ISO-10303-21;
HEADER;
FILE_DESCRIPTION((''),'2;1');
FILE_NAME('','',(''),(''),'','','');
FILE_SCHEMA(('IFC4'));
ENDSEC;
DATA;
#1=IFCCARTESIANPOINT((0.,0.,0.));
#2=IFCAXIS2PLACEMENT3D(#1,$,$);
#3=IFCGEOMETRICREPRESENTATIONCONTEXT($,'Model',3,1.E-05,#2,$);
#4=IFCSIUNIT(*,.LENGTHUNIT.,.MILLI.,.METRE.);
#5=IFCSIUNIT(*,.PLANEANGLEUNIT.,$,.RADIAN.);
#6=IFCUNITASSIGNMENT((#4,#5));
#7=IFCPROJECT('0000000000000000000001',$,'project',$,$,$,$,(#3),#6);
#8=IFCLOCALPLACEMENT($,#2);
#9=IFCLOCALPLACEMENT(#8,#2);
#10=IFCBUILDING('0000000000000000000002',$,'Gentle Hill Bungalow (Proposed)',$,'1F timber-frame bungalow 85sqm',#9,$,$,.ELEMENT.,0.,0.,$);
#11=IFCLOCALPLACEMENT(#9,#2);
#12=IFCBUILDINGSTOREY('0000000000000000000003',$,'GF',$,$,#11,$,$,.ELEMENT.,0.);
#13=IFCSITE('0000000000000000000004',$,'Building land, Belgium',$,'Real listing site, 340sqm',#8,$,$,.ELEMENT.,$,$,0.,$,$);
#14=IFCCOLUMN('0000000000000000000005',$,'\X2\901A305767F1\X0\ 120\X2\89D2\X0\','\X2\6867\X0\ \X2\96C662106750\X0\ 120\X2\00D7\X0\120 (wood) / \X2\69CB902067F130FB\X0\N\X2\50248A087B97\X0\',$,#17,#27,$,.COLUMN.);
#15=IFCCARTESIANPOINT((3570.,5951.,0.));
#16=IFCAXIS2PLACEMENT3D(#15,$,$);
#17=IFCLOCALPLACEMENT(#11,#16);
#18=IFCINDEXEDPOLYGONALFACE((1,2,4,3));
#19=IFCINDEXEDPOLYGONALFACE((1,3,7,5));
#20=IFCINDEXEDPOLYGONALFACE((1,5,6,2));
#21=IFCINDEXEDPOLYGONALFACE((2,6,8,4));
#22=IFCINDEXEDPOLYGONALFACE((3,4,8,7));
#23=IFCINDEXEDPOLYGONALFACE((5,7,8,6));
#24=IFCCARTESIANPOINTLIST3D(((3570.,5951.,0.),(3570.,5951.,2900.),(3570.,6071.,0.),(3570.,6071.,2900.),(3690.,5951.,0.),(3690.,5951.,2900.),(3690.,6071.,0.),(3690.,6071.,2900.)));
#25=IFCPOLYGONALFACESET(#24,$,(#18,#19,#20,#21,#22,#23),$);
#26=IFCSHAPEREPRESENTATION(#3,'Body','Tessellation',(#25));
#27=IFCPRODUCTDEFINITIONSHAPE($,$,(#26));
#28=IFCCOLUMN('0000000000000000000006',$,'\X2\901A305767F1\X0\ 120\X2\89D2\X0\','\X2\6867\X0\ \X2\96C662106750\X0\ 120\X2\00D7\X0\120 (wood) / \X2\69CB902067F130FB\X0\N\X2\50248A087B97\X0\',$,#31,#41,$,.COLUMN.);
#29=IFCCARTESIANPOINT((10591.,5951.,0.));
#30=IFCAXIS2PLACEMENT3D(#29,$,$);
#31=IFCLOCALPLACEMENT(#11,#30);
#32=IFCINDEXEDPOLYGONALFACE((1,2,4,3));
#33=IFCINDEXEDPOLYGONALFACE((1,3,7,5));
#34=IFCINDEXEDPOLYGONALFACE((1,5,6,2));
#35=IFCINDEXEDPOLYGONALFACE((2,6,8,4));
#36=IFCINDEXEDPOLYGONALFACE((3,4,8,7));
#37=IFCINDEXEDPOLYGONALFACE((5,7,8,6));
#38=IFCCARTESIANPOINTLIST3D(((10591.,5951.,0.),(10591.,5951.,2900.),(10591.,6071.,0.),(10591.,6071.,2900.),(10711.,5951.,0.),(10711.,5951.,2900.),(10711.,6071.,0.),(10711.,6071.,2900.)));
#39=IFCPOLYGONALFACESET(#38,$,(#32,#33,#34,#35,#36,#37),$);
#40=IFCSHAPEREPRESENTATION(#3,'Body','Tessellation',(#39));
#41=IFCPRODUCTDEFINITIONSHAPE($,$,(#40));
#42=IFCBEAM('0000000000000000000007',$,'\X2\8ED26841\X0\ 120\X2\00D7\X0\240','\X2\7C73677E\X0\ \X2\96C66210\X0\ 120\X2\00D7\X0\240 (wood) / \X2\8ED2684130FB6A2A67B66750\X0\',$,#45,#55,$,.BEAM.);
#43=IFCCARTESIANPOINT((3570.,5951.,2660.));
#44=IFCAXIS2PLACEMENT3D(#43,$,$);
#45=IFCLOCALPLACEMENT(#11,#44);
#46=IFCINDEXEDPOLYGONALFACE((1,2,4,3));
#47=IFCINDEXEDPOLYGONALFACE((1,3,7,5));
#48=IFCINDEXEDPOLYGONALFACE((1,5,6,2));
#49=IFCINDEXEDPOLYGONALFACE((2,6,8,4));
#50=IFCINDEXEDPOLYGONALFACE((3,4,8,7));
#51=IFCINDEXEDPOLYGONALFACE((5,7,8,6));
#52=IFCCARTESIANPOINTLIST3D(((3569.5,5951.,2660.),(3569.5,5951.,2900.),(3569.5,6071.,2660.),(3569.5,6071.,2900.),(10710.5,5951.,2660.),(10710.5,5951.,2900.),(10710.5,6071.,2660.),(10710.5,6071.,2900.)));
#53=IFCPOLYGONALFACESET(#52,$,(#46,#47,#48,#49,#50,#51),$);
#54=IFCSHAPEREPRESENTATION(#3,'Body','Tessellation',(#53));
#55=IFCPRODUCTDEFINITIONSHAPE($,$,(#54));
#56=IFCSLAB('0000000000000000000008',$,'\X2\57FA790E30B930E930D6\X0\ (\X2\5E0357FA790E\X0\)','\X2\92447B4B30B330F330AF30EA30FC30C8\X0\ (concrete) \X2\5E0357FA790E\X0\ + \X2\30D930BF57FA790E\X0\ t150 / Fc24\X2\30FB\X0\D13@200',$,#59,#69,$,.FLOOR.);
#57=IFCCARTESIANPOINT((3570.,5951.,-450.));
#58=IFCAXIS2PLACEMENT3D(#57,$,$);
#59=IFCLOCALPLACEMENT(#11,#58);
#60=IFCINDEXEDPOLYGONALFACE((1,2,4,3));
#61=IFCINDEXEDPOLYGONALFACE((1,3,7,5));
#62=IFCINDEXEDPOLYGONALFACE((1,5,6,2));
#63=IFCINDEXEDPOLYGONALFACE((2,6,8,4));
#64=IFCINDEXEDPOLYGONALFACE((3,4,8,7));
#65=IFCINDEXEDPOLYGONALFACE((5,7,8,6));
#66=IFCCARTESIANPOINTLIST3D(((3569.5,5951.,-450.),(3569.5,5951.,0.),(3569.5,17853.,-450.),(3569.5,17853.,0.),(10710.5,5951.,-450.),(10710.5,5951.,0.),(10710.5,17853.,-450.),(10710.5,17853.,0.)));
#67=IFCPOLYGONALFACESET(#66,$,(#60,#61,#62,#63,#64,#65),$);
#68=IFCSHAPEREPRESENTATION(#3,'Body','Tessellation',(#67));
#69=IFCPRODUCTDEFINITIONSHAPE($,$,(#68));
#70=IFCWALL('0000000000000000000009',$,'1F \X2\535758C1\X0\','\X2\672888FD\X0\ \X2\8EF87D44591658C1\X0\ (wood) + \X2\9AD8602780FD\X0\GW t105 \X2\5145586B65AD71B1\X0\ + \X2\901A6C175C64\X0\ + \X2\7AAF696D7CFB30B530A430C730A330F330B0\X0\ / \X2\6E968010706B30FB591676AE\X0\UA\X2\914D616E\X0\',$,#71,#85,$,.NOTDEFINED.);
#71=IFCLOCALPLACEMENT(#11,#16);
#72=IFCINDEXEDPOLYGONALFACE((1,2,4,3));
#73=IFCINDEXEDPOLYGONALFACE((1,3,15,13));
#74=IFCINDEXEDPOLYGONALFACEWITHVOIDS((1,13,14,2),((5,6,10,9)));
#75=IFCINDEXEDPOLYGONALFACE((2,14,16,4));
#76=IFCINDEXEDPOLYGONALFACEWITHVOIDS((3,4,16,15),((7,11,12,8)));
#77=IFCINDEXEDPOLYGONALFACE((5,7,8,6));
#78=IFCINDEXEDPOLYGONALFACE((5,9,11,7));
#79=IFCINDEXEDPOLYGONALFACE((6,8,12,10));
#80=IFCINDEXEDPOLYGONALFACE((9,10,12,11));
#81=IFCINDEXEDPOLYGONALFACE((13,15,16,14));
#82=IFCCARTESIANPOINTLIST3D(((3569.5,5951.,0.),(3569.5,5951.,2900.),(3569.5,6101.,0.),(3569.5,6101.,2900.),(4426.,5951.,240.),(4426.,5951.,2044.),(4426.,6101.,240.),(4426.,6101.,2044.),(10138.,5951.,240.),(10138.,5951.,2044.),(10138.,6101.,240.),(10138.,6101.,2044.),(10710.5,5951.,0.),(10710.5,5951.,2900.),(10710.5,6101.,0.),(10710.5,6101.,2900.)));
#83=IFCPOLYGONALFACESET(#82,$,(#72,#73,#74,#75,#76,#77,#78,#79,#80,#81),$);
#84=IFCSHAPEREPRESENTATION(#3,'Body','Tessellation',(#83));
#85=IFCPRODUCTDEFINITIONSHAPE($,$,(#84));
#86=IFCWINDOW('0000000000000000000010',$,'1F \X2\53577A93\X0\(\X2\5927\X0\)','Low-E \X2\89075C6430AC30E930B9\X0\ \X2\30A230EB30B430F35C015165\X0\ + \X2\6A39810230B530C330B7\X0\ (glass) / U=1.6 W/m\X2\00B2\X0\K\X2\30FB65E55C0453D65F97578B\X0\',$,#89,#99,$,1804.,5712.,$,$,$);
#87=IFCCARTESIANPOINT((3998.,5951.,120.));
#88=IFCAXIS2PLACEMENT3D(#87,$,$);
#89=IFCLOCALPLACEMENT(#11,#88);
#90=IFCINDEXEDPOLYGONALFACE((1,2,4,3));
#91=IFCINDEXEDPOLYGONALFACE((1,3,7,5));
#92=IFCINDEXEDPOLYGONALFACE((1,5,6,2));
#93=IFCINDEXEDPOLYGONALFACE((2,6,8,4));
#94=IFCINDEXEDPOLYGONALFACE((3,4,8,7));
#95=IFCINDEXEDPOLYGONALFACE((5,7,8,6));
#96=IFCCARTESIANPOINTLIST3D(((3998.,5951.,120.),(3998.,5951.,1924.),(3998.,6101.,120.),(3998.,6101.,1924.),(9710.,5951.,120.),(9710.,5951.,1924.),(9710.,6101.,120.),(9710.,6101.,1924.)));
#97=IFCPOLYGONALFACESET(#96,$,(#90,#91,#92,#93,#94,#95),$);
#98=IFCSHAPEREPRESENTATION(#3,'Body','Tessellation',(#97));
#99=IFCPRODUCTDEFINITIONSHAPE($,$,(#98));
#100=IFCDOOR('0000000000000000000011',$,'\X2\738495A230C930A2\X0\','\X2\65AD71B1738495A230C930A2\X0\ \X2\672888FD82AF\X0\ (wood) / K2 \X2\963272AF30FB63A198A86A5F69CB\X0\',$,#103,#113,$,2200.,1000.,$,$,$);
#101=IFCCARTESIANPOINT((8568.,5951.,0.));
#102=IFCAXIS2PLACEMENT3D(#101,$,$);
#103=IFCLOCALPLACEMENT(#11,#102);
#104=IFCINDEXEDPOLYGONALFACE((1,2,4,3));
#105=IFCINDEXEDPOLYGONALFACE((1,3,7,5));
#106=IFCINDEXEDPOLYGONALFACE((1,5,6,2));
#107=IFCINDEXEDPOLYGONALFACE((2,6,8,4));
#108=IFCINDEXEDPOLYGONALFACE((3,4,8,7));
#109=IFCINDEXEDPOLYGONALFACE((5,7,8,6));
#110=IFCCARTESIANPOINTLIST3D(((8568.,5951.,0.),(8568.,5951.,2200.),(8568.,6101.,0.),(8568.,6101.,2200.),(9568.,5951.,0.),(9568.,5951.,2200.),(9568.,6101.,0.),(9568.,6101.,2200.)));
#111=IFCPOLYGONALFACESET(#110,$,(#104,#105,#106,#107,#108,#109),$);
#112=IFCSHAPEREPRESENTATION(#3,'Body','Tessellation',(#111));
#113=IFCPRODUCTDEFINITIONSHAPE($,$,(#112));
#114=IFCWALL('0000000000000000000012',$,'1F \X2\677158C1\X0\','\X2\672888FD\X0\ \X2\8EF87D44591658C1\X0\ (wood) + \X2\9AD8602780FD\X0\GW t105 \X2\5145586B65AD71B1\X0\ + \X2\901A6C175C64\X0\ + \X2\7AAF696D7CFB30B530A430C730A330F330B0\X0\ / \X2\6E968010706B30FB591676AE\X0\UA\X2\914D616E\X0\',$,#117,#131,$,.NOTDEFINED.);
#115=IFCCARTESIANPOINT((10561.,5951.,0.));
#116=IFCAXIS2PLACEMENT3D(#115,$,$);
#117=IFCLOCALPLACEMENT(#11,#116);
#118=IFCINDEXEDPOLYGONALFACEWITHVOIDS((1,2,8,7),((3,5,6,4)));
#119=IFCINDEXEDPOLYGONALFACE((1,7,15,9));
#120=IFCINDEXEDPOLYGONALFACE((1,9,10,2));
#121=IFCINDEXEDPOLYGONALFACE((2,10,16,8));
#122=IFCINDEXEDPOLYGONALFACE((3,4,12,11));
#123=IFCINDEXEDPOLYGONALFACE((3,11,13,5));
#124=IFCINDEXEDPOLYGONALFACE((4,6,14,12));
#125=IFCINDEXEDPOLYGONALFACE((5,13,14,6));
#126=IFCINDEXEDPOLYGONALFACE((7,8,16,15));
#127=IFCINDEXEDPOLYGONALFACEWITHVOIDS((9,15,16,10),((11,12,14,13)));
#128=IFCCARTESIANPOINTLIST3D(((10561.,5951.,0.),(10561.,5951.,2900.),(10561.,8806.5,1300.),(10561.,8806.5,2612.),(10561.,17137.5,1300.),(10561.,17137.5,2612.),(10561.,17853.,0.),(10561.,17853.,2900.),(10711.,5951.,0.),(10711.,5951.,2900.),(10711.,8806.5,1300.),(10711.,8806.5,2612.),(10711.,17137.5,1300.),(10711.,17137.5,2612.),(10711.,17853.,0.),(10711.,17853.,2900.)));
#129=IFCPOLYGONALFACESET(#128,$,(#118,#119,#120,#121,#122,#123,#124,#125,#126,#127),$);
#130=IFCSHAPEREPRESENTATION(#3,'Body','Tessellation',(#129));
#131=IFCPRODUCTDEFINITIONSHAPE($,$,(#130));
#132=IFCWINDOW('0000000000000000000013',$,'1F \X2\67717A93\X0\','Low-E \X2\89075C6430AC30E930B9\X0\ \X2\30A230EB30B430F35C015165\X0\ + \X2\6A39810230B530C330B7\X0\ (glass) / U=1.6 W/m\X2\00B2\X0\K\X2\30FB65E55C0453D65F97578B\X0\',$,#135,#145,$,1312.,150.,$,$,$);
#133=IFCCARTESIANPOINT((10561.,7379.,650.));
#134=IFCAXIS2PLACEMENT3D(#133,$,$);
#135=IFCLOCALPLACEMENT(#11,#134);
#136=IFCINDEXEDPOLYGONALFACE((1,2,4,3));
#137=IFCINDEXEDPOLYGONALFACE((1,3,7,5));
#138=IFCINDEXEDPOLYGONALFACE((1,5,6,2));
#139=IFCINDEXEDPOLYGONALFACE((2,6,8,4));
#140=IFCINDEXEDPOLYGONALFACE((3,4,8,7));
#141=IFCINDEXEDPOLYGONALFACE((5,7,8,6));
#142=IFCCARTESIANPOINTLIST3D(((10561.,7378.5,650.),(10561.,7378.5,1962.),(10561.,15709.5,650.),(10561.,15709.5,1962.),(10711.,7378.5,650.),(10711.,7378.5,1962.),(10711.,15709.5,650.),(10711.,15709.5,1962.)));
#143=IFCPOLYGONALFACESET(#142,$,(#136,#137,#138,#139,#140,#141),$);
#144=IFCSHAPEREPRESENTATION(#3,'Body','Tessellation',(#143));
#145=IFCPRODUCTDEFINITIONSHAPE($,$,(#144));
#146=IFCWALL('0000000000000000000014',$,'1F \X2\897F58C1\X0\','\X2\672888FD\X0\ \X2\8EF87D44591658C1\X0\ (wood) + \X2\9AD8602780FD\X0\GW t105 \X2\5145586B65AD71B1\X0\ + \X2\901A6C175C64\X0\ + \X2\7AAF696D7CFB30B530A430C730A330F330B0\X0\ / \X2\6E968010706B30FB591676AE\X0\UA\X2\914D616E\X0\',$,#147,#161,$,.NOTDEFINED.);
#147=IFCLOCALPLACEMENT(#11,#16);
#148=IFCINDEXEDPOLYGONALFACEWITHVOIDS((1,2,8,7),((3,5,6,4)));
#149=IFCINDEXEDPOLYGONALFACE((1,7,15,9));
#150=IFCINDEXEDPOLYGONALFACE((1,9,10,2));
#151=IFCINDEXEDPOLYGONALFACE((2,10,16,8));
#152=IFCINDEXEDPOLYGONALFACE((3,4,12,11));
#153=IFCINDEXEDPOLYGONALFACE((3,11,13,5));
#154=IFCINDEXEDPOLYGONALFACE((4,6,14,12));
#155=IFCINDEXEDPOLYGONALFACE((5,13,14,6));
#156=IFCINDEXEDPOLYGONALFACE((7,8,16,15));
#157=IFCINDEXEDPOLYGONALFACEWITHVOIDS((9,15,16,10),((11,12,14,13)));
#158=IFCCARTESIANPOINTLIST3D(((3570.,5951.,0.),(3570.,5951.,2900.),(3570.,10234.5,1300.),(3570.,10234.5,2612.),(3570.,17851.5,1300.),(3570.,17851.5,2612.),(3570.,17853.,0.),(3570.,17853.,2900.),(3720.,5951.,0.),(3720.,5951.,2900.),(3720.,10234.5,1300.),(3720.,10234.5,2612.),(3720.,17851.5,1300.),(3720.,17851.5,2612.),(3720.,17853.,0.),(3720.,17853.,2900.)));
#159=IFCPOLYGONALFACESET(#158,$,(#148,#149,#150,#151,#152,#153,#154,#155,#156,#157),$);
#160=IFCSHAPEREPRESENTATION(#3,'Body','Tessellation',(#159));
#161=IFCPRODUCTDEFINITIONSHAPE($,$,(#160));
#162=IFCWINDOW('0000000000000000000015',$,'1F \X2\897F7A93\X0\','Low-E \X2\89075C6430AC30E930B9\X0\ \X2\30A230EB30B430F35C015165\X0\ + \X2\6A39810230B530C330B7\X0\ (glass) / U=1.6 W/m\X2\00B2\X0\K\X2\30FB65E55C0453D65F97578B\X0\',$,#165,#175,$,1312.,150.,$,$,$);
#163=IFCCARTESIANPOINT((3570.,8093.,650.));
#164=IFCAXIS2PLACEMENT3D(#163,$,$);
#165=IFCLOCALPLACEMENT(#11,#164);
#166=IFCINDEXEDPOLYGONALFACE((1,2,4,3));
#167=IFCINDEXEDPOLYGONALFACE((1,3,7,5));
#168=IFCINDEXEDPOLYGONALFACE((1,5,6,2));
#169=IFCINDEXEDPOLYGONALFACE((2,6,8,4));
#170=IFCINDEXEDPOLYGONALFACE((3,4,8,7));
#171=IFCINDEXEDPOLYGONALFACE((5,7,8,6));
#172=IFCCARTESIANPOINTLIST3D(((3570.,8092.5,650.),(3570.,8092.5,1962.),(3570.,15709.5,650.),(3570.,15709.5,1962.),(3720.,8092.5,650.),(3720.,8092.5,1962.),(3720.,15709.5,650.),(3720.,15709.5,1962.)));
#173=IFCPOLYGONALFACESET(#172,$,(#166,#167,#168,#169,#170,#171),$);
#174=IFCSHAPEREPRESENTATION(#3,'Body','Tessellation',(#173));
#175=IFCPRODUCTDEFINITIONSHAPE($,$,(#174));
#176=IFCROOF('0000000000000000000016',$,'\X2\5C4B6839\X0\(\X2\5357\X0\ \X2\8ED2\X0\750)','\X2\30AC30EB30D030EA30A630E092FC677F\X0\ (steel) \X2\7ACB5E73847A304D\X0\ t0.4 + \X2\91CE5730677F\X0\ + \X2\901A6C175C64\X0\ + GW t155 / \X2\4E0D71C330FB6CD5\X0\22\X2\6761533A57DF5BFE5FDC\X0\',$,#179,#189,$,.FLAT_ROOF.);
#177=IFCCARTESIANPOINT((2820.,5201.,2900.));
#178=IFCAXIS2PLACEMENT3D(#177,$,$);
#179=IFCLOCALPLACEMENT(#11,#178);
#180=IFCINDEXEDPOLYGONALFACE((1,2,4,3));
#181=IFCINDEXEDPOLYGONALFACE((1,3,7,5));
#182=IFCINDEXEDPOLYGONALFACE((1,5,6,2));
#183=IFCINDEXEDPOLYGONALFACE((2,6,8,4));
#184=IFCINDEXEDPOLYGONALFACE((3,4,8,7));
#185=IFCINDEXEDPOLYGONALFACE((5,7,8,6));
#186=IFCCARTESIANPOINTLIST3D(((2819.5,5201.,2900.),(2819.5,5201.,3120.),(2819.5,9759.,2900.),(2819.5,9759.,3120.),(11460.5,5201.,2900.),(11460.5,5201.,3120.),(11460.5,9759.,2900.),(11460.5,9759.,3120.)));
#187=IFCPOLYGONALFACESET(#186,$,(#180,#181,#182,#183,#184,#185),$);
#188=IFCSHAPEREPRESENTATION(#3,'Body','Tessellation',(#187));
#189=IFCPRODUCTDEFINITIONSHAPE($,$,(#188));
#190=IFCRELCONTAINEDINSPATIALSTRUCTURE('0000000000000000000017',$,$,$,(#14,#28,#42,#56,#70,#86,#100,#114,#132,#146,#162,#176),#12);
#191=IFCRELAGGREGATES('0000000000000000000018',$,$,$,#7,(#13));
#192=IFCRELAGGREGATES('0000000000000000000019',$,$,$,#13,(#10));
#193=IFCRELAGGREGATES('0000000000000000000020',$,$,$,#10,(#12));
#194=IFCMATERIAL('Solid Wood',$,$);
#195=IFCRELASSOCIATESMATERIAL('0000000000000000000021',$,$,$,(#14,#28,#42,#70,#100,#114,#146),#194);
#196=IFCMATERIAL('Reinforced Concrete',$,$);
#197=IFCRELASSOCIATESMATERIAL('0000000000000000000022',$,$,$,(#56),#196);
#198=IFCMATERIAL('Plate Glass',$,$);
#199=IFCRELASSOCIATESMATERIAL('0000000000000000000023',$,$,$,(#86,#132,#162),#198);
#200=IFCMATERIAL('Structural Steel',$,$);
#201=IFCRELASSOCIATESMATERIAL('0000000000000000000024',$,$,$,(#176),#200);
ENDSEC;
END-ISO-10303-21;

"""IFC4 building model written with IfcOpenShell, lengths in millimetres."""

from ifc_helpers import new_model, si_unit, frame, frame_2d, origin, place, context, project, spatial, rectangle, extrude, material, element, fill, save


model = new_model("IFC4")

# Units and contexts
model_context = context("Model", 3, precision=1e-05, world=origin())
ifc_project = project(units=[si_unit("LENGTHUNIT", "METRE", prefix="MILLI"), si_unit("PLANEANGLEUNIT", "RADIAN")], contexts=[model_context])

# Site, building, storey
site_placement = place(None, origin())
site = spatial("IfcSite", under=ifc_project, at=site_placement, Name="Building land, Belgium", ObjectType="Real listing site, 340sqm", CompositionType="ELEMENT", RefElevation=0.0)
building_placement = place(site_placement, origin())
building = spatial("IfcBuilding", under=site, at=building_placement, Name="Gentle Hill Bungalow (Proposed)", ObjectType="1F timber-frame bungalow 85sqm", CompositionType="ELEMENT", ElevationOfRefHeight=0.0, ElevationOfTerrain=0.0)
storey_placement = place(building_placement, origin())
storey = spatial("IfcBuildingStorey", under=building, at=storey_placement, Name="GF", CompositionType="ELEMENT", Elevation=0.0)

# Columns
ifc_material_1 = material(Name="Solid Wood")
column_1_placement = place(storey_placement, frame((3570.0, 5951.0, 0.0)))
element("IfcColumn", 1, at=column_1_placement, inside=storey, material=ifc_material_1, Name="通し柱 120角", Description="桧 集成材 120×120 (wood) / 構造柱・N値計算", PredefinedType="COLUMN", context=model_context, shape_type="SweptSolid", body=[
    extrude(rectangle(XDim=120.0, YDim=120.0, at=frame_2d((60.0, 60.0))), frame((3570.0, 5951.0, 0.0)), (0.0, 0.0, 1.0), 2900.0),
])
column_2_placement = place(storey_placement, frame((10591.0, 5951.0, 0.0)))
element("IfcColumn", 2, at=column_2_placement, inside=storey, material=ifc_material_1, Name="通し柱 120角", Description="桧 集成材 120×120 (wood) / 構造柱・N値計算", PredefinedType="COLUMN", context=model_context, shape_type="SweptSolid", body=[
    extrude(rectangle(XDim=120.0, YDim=120.0, at=frame_2d((60.0, 60.0))), frame((10591.0, 5951.0, 0.0)), (0.0, 0.0, 1.0), 2900.0),
])

# Beam
beam_1_placement = place(storey_placement, frame((3570.0, 5951.0, 2660.0)))
element("IfcBeam", 3, at=beam_1_placement, inside=storey, material=ifc_material_1, Name="軒桁 120×240", Description="米松 集成 120×240 (wood) / 軒桁・横架材", PredefinedType="BEAM", context=model_context, shape_type="SweptSolid", body=[
    extrude(rectangle(XDim=7141.0, YDim=120.0, at=frame_2d((3570.0, 60.0))), frame((3570.0, 5951.0, 2660.0)), (0.0, 0.0, 1.0), 240.0),
])

# Slab
ifc_material_2 = material(Name="Reinforced Concrete")
slab_1_placement = place(storey_placement, frame((3570.0, 5951.0, -450.0)))
element("IfcSlab", 4, at=slab_1_placement, inside=storey, material=ifc_material_2, Name="基礎スラブ (布基礎)", Description="鉄筋コンクリート (concrete) 布基礎 + ベタ基礎 t150 / Fc24・D13@200", PredefinedType="FLOOR", context=model_context, shape_type="SweptSolid", body=[
    extrude(rectangle(XDim=7141.0, YDim=11902.0, at=frame_2d((3570.0, 5951.0))), frame((3570.0, 5951.0, -450.0)), (0.0, 0.0, 1.0), 450.0),
])

# Wall, openings, window, door
wall_1_placement = place(storey_placement, frame((3570.0, 5951.0, 0.0)))
wall_1 = element("IfcWall", 5, at=wall_1_placement, inside=storey, material=ifc_material_1, Name="1F 南壁", Description="木製 軸組外壁 (wood) + 高性能GW t105 充填断熱 + 通気層 + 窯業系サイディング / 準耐火・外皮UA配慮", PredefinedType="NOTDEFINED", context=model_context, shape_type="SweptSolid", body=[
    extrude(rectangle(XDim=7141.0, YDim=150.0, at=frame_2d((3570.0, 75.0))), frame((3570.0, 5951.0, 0.0)), (0.0, 0.0, 1.0), 2900.0),
])
opening_1_placement = place(storey_placement, frame((3998.0, 5951.0, 120.0)))
opening_1 = element("IfcOpeningElement", 6, at=opening_1_placement, cuts=wall_1, PredefinedType="NOTDEFINED", context=model_context, shape_type="SweptSolid", body=[
    extrude(rectangle(XDim=5712.0, YDim=150.0, at=frame_2d((2856.0, 75.0))), frame((3998.0, 5951.0, 120.0)), (0.0, 0.0, 1.0), 1804.0),
])
opening_2_placement = place(storey_placement, frame((8568.0, 5951.0, 0.0)))
opening_2 = element("IfcOpeningElement", 7, at=opening_2_placement, cuts=wall_1, PredefinedType="NOTDEFINED", context=model_context, shape_type="SweptSolid", body=[
    extrude(rectangle(XDim=1000.0, YDim=150.0, at=frame_2d((500.0, 75.0))), frame((8568.0, 5951.0, 0.0)), (0.0, 0.0, 1.0), 2200.0),
])
ifc_material_3 = material(Name="Plate Glass")
window_1_placement = place(storey_placement, frame((3998.0, 5951.0, 120.0)))
window_1 = element("IfcWindow", 8, at=window_1_placement, inside=storey, material=ifc_material_3, Name="1F 南窓(大)", Description="Low-E 複層ガラス アルゴン封入 + 樹脂サッシ (glass) / U=1.6 W/m²K・日射取得型", OverallHeight=1804.0, OverallWidth=5712.0, context=model_context, shape_type="SweptSolid", body=[
    extrude(rectangle(XDim=5712.0, YDim=150.0, at=frame_2d((2856.0, 75.0))), frame((3998.0, 5951.0, 120.0)), (0.0, 0.0, 1.0), 1804.0),
])
fill(opening_1, window_1)
door_placement = place(storey_placement, frame((8568.0, 5951.0, 0.0)))
door = element("IfcDoor", 9, at=door_placement, inside=storey, material=ifc_material_1, Name="玄関ドア", Description="断熱玄関ドア 木製芯 (wood) / K2 防犯・採風機構", OverallHeight=2200.0, OverallWidth=1000.0, context=model_context, shape_type="SweptSolid", body=[
    extrude(rectangle(XDim=1000.0, YDim=150.0, at=frame_2d((500.0, 75.0))), frame((8568.0, 5951.0, 0.0)), (0.0, 0.0, 1.0), 2200.0),
])
fill(opening_2, door)

# Walls, openings, windows
wall_2_placement = place(storey_placement, frame((10561.0, 5951.0, 0.0)))
wall_2 = element("IfcWall", 10, at=wall_2_placement, inside=storey, material=ifc_material_1, Name="1F 東壁", Description="木製 軸組外壁 (wood) + 高性能GW t105 充填断熱 + 通気層 + 窯業系サイディング / 準耐火・外皮UA配慮", PredefinedType="NOTDEFINED", context=model_context, shape_type="SweptSolid", body=[
    extrude(rectangle(XDim=150.0, YDim=11902.0, at=frame_2d((75.0, 5951.0))), frame((10561.0, 5951.0, 0.0)), (0.0, 0.0, 1.0), 2900.0),
])
opening_3_placement = place(storey_placement, frame((10561.0, 7379.0, 650.0)))
opening_3 = element("IfcOpeningElement", 11, at=opening_3_placement, cuts=wall_2, PredefinedType="NOTDEFINED", context=model_context, shape_type="SweptSolid", body=[
    extrude(rectangle(XDim=150.0, YDim=8331.0, at=frame_2d((75.0, 4165.0))), frame((10561.0, 7379.0, 650.0)), (0.0, 0.0, 1.0), 1312.0),
])
window_2_placement = place(storey_placement, frame((10561.0, 7379.0, 650.0)))
window_2 = element("IfcWindow", 12, at=window_2_placement, inside=storey, material=ifc_material_3, Name="1F 東窓", Description="Low-E 複層ガラス アルゴン封入 + 樹脂サッシ (glass) / U=1.6 W/m²K・日射取得型", OverallHeight=1312.0, OverallWidth=150.0, context=model_context, shape_type="SweptSolid", body=[
    extrude(rectangle(XDim=150.0, YDim=8331.0, at=frame_2d((75.0, 4165.0))), frame((10561.0, 7379.0, 650.0)), (0.0, 0.0, 1.0), 1312.0),
])
fill(opening_3, window_2)
wall_3_placement = place(storey_placement, frame((3570.0, 5951.0, 0.0)))
wall_3 = element("IfcWall", 13, at=wall_3_placement, inside=storey, material=ifc_material_1, Name="1F 西壁", Description="木製 軸組外壁 (wood) + 高性能GW t105 充填断熱 + 通気層 + 窯業系サイディング / 準耐火・外皮UA配慮", PredefinedType="NOTDEFINED", context=model_context, shape_type="SweptSolid", body=[
    extrude(rectangle(XDim=150.0, YDim=11902.0, at=frame_2d((75.0, 5951.0))), frame((3570.0, 5951.0, 0.0)), (0.0, 0.0, 1.0), 2900.0),
])
opening_4_placement = place(storey_placement, frame((3570.0, 8093.0, 650.0)))
opening_4 = element("IfcOpeningElement", 14, at=opening_4_placement, cuts=wall_3, PredefinedType="NOTDEFINED", context=model_context, shape_type="SweptSolid", body=[
    extrude(rectangle(XDim=150.0, YDim=7617.0, at=frame_2d((75.0, 3808.0))), frame((3570.0, 8093.0, 650.0)), (0.0, 0.0, 1.0), 1312.0),
])
window_3_placement = place(storey_placement, frame((3570.0, 8093.0, 650.0)))
window_3 = element("IfcWindow", 15, at=window_3_placement, inside=storey, material=ifc_material_3, Name="1F 西窓", Description="Low-E 複層ガラス アルゴン封入 + 樹脂サッシ (glass) / U=1.6 W/m²K・日射取得型", OverallHeight=1312.0, OverallWidth=150.0, context=model_context, shape_type="SweptSolid", body=[
    extrude(rectangle(XDim=150.0, YDim=7617.0, at=frame_2d((75.0, 3808.0))), frame((3570.0, 8093.0, 650.0)), (0.0, 0.0, 1.0), 1312.0),
])
fill(opening_4, window_3)

# Roof
ifc_material_4 = material(Name="Structural Steel")
roof_placement = place(storey_placement, frame((2820.0, 5201.0, 2900.0)))
element("IfcRoof", 16, at=roof_placement, inside=storey, material=ifc_material_4, Name="屋根(南 軒750)", Description="ガルバリウム鋼板 (steel) 立平葺き t0.4 + 野地板 + 通気層 + GW t155 / 不燃・法22条区域対応", PredefinedType="FLAT_ROOF", context=model_context, shape_type="SweptSolid", body=[
    extrude(rectangle(XDim=8641.0, YDim=4558.0, at=frame_2d((4320.0, 2279.0))), frame((2820.0, 5201.0, 2900.0)), (0.0, 0.0, 1.0), 220.0),
])

save(model, "model.ifc")
